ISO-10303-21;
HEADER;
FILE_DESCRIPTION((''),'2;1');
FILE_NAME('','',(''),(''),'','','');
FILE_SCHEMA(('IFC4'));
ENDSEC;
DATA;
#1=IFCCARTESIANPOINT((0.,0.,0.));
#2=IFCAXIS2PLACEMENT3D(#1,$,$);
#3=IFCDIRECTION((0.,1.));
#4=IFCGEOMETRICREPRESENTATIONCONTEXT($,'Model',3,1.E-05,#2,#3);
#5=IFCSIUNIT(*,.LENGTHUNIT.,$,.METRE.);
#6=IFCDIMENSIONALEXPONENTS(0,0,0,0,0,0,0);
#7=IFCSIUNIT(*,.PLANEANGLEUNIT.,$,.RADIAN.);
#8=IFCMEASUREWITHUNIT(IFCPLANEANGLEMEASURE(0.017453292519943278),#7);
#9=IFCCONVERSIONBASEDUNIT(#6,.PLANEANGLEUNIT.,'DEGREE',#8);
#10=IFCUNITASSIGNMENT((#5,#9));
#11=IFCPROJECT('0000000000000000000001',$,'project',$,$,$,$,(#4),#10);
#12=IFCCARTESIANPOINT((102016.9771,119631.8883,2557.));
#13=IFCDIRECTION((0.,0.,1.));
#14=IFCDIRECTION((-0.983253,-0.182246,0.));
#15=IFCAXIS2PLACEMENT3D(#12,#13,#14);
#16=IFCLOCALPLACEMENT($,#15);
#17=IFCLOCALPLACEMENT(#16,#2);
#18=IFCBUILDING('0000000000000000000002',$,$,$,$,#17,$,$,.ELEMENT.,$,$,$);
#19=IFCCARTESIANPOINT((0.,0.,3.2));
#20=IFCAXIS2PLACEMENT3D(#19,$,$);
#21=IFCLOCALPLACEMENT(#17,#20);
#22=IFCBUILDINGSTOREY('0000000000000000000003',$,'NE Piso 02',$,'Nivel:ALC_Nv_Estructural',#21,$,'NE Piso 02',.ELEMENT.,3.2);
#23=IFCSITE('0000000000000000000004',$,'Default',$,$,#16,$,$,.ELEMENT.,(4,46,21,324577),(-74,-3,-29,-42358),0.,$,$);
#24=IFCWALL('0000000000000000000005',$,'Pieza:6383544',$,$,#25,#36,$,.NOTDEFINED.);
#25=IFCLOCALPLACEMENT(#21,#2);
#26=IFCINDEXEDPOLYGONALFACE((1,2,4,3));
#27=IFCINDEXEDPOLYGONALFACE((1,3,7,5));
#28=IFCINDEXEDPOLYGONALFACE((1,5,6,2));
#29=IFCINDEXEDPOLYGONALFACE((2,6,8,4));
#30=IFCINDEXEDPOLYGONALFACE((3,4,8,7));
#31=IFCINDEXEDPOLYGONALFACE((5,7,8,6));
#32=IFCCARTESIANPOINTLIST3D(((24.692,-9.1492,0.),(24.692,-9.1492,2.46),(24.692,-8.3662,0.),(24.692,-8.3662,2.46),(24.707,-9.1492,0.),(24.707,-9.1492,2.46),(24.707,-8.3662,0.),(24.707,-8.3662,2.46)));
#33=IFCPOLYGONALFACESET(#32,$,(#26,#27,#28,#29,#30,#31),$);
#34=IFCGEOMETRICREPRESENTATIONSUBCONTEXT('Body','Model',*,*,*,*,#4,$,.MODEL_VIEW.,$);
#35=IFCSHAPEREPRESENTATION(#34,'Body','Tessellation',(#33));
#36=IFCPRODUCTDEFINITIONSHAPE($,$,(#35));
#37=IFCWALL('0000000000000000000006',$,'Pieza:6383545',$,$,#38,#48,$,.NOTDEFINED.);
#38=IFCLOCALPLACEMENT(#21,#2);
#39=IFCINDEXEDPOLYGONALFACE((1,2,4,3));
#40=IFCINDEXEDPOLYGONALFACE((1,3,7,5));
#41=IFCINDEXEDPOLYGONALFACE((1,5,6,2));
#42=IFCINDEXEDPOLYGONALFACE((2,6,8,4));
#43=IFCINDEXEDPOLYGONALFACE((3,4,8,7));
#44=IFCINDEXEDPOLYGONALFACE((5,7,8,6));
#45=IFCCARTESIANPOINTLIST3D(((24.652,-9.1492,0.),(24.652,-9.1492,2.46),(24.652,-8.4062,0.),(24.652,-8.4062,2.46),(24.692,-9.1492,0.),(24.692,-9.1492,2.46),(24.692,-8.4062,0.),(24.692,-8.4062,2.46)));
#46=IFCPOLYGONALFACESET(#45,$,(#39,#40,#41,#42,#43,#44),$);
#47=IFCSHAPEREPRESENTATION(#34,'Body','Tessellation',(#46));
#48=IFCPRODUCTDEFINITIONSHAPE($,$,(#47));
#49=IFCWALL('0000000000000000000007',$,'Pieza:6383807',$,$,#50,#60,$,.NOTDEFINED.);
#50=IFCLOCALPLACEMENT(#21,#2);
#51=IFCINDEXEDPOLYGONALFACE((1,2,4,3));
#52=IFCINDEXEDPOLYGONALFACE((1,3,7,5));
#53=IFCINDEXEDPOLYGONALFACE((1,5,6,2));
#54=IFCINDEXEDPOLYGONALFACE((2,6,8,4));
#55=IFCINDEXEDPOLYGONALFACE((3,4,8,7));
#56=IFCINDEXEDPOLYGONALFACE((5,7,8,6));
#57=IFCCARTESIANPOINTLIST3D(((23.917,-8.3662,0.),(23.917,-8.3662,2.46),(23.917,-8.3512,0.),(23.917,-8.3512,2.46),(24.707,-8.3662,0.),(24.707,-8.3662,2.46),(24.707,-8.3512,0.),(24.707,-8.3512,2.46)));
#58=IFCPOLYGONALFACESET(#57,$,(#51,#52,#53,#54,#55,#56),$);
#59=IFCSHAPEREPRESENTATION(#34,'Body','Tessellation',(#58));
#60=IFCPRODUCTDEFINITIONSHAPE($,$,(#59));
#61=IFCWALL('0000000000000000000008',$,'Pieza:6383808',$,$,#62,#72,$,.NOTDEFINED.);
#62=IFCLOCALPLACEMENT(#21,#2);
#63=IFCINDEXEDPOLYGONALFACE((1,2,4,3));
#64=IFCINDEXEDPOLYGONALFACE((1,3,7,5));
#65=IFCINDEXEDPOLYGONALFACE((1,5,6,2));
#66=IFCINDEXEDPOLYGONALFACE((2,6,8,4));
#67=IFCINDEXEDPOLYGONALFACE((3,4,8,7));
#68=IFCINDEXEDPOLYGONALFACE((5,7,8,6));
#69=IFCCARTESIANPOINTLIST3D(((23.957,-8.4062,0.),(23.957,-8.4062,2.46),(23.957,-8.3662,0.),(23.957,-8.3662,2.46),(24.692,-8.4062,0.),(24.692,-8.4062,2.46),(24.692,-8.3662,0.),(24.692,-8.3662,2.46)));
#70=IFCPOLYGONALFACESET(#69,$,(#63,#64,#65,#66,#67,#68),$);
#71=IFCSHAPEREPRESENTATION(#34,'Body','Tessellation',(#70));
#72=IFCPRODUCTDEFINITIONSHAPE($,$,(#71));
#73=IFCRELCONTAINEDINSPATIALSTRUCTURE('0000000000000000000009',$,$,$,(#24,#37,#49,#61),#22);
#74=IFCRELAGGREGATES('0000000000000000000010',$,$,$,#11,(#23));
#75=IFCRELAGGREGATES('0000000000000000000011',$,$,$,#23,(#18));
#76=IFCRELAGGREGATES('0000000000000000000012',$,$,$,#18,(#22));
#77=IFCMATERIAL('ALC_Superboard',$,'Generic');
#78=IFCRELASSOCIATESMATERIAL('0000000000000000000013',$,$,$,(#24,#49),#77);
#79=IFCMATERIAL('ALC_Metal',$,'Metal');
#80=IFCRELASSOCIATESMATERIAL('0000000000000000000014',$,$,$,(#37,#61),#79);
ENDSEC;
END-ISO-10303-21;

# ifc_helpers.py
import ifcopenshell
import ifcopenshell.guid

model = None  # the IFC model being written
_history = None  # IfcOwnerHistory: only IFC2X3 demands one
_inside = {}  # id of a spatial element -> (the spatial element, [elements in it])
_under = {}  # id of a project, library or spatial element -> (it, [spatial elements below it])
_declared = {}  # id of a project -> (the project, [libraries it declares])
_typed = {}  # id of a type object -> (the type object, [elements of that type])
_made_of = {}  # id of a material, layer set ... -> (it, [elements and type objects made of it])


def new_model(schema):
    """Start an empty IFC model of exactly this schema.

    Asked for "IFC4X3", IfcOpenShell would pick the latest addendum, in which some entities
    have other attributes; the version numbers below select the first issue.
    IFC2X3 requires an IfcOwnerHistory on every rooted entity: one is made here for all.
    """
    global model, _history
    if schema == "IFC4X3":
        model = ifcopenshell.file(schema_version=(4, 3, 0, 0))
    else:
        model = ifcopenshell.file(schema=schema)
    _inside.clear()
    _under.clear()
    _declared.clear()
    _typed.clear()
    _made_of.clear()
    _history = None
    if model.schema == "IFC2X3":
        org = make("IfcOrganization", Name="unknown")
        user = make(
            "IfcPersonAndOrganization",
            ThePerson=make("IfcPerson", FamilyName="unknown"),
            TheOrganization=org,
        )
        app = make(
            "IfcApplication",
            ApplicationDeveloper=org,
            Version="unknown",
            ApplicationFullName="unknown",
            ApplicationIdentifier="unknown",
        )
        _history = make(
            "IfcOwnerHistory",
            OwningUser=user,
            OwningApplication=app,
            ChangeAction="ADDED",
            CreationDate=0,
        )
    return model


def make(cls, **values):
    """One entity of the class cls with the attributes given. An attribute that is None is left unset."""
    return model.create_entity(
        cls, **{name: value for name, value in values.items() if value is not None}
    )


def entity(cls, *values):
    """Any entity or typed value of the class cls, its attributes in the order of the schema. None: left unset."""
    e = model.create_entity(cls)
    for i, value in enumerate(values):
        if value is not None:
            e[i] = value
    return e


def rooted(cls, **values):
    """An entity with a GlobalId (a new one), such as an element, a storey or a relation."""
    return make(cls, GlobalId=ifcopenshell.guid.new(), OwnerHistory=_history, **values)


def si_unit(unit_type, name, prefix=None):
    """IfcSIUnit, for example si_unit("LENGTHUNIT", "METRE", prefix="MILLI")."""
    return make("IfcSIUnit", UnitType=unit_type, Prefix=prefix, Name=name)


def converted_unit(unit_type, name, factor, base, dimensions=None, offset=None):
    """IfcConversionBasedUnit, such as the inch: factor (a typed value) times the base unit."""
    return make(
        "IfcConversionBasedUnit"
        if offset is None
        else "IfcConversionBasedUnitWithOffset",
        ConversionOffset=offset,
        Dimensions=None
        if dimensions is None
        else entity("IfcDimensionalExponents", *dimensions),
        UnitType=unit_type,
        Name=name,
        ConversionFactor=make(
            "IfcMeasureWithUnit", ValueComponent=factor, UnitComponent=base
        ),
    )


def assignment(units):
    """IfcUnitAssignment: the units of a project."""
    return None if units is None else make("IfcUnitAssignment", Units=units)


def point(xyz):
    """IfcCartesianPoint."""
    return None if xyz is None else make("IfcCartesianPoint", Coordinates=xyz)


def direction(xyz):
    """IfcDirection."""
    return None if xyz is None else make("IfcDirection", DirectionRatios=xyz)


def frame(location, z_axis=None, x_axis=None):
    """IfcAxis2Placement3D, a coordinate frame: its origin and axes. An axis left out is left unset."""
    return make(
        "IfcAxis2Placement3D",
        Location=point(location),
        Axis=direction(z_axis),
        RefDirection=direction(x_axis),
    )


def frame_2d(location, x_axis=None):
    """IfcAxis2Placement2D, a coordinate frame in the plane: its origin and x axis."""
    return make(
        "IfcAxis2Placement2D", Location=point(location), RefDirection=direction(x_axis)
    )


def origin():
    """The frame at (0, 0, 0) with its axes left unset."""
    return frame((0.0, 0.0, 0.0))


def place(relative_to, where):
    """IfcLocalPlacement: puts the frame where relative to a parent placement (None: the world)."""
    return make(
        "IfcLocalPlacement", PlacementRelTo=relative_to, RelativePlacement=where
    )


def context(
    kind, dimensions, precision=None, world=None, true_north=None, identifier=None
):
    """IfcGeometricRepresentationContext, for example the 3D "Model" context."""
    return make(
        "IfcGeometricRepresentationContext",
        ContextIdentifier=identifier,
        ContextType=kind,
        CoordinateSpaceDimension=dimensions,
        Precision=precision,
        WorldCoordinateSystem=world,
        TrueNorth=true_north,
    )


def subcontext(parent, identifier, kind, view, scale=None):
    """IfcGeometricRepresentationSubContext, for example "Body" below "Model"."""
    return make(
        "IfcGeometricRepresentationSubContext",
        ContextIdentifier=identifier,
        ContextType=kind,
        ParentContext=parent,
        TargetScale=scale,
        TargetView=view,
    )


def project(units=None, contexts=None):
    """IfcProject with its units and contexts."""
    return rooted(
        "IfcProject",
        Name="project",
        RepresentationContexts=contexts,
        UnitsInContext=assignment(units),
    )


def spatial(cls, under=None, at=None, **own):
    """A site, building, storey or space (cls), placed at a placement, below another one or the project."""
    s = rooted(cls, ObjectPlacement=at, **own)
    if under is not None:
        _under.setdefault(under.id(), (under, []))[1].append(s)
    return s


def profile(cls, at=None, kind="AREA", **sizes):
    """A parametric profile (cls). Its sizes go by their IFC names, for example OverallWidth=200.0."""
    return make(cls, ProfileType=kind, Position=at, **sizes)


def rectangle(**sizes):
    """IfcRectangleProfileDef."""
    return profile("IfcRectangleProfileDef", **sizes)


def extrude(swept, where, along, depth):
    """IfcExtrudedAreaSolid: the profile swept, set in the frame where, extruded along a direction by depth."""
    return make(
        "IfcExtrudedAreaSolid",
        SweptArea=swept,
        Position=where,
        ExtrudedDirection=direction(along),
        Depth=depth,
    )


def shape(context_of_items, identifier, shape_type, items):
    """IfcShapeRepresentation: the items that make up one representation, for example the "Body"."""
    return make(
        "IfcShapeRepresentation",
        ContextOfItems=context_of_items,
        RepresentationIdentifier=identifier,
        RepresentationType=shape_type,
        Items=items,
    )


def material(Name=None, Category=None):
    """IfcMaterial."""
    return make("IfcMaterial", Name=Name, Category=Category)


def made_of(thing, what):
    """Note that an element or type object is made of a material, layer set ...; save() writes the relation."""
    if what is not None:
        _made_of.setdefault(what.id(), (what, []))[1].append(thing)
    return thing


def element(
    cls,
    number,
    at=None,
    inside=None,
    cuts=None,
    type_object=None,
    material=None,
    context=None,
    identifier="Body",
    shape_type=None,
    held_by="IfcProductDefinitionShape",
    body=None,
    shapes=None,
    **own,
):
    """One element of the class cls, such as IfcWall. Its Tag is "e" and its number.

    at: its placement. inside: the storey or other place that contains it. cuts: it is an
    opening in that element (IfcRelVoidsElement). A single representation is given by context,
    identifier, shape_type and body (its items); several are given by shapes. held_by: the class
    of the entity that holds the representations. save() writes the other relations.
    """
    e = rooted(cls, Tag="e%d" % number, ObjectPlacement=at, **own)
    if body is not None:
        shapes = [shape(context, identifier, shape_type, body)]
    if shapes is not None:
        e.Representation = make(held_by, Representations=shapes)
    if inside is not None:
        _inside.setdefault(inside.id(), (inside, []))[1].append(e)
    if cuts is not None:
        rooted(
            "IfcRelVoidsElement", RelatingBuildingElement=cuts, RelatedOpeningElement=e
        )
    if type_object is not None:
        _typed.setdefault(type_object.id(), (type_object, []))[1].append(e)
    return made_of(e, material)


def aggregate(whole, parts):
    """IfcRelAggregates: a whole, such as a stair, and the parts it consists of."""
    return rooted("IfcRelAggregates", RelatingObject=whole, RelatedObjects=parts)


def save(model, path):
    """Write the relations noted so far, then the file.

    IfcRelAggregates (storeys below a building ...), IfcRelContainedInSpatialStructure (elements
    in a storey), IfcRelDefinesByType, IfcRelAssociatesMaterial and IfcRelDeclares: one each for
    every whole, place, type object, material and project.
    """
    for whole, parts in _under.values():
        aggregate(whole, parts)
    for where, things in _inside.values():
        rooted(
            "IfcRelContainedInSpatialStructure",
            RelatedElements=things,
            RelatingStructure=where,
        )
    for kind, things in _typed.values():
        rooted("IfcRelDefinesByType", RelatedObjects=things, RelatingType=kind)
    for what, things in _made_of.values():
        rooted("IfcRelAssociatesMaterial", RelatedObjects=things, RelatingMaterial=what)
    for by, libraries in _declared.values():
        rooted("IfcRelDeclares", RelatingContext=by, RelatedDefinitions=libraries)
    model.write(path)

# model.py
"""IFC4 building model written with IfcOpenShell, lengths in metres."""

from ifc_helpers import new_model, entity, si_unit, converted_unit, direction, frame, frame_2d, origin, place, context, subcontext, project, spatial, rectangle, extrude, material, element, save


model = new_model("IFC4")

# Units and contexts
model_context = context("Model", 3, precision=1e-05, world=origin(), true_north=direction((0.0, 1.0)))
body_context = subcontext(model_context, "Body", "Model", "MODEL_VIEW")
ifc_project = project(units=[si_unit("LENGTHUNIT", "METRE"), converted_unit("PLANEANGLEUNIT", "DEGREE", entity("IfcPlaneAngleMeasure", 0.017453292519943278), si_unit("PLANEANGLEUNIT", "RADIAN"), dimensions=[0, 0, 0, 0, 0, 0, 0])], contexts=[model_context])

# Site, building, storey
site_placement = place(None, frame((102016.9771, 119631.8883, 2557.0), z_axis=(0.0, 0.0, 1.0), x_axis=(-0.983253, -0.182246, 0.0)))
site = spatial("IfcSite", under=ifc_project, at=site_placement, Name="Default", CompositionType="ELEMENT", RefLatitude=(4, 46, 21, 324577), RefLongitude=(-74, -3, -29, -42358), RefElevation=0.0)
building_placement = place(site_placement, origin())
building = spatial("IfcBuilding", under=site, at=building_placement, CompositionType="ELEMENT")
storey_placement = place(building_placement, frame((0.0, 0.0, 3.2)))
storey = spatial("IfcBuildingStorey", under=building, at=storey_placement, Name="NE Piso 02", ObjectType="Nivel:ALC_Nv_Estructural", LongName="NE Piso 02", CompositionType="ELEMENT", Elevation=3.2)

# Walls
ifc_material_1 = material(Name="ALC_Superboard", Category="Generic")
wall_1_placement = place(storey_placement, origin())
element("IfcWall", 1, at=wall_1_placement, inside=storey, material=ifc_material_1, Name="Pieza:6383544", PredefinedType="NOTDEFINED", context=body_context, shape_type="SweptSolid", body=[
    extrude(rectangle(XDim=0.783, YDim=0.015, at=frame_2d((0.0, 0.0), x_axis=(1.0, 0.0))), frame((24.6995, -8.7577, 0.0), z_axis=(0.0, 0.0, 1.0), x_axis=(0.0, -1.0, 0.0)), (0.0, 0.0, 1.0), 2.46),
])
ifc_material_2 = material(Name="ALC_Metal", Category="Metal")
wall_2_placement = place(storey_placement, origin())
element("IfcWall", 2, at=wall_2_placement, inside=storey, material=ifc_material_2, Name="Pieza:6383545", PredefinedType="NOTDEFINED", context=body_context, shape_type="SweptSolid", body=[
    extrude(rectangle(XDim=0.743, YDim=0.04, at=frame_2d((0.0, 0.0), x_axis=(1.0, 0.0))), frame((24.672, -8.7777, 0.0), z_axis=(0.0, 0.0, 1.0), x_axis=(0.0, -1.0, 0.0)), (0.0, 0.0, 1.0), 2.46),
])
wall_3_placement = place(storey_placement, origin())
element("IfcWall", 3, at=wall_3_placement, inside=storey, material=ifc_material_1, Name="Pieza:6383807", PredefinedType="NOTDEFINED", context=body_context, shape_type="SweptSolid", body=[
    extrude(rectangle(XDim=0.015, YDim=0.79, at=frame_2d((0.0, 0.0), x_axis=(1.0, 0.0))), frame((24.312, -8.3587, 0.0), z_axis=(0.0, 0.0, 1.0), x_axis=(0.0, -1.0, 0.0)), (0.0, 0.0, 1.0), 2.46),
])
wall_4_placement = place(storey_placement, origin())
element("IfcWall", 4, at=wall_4_placement, inside=storey, material=ifc_material_2, Name="Pieza:6383808", PredefinedType="NOTDEFINED", context=body_context, shape_type="SweptSolid", body=[
    extrude(rectangle(XDim=0.04, YDim=0.735, at=frame_2d((0.0, 0.0), x_axis=(1.0, 0.0))), frame((24.3245, -8.3862, 0.0), z_axis=(0.0, 0.0, 1.0), x_axis=(0.0, -1.0, 0.0)), (0.0, 0.0, 1.0), 2.46),
])

save(model, "model.ifc")
